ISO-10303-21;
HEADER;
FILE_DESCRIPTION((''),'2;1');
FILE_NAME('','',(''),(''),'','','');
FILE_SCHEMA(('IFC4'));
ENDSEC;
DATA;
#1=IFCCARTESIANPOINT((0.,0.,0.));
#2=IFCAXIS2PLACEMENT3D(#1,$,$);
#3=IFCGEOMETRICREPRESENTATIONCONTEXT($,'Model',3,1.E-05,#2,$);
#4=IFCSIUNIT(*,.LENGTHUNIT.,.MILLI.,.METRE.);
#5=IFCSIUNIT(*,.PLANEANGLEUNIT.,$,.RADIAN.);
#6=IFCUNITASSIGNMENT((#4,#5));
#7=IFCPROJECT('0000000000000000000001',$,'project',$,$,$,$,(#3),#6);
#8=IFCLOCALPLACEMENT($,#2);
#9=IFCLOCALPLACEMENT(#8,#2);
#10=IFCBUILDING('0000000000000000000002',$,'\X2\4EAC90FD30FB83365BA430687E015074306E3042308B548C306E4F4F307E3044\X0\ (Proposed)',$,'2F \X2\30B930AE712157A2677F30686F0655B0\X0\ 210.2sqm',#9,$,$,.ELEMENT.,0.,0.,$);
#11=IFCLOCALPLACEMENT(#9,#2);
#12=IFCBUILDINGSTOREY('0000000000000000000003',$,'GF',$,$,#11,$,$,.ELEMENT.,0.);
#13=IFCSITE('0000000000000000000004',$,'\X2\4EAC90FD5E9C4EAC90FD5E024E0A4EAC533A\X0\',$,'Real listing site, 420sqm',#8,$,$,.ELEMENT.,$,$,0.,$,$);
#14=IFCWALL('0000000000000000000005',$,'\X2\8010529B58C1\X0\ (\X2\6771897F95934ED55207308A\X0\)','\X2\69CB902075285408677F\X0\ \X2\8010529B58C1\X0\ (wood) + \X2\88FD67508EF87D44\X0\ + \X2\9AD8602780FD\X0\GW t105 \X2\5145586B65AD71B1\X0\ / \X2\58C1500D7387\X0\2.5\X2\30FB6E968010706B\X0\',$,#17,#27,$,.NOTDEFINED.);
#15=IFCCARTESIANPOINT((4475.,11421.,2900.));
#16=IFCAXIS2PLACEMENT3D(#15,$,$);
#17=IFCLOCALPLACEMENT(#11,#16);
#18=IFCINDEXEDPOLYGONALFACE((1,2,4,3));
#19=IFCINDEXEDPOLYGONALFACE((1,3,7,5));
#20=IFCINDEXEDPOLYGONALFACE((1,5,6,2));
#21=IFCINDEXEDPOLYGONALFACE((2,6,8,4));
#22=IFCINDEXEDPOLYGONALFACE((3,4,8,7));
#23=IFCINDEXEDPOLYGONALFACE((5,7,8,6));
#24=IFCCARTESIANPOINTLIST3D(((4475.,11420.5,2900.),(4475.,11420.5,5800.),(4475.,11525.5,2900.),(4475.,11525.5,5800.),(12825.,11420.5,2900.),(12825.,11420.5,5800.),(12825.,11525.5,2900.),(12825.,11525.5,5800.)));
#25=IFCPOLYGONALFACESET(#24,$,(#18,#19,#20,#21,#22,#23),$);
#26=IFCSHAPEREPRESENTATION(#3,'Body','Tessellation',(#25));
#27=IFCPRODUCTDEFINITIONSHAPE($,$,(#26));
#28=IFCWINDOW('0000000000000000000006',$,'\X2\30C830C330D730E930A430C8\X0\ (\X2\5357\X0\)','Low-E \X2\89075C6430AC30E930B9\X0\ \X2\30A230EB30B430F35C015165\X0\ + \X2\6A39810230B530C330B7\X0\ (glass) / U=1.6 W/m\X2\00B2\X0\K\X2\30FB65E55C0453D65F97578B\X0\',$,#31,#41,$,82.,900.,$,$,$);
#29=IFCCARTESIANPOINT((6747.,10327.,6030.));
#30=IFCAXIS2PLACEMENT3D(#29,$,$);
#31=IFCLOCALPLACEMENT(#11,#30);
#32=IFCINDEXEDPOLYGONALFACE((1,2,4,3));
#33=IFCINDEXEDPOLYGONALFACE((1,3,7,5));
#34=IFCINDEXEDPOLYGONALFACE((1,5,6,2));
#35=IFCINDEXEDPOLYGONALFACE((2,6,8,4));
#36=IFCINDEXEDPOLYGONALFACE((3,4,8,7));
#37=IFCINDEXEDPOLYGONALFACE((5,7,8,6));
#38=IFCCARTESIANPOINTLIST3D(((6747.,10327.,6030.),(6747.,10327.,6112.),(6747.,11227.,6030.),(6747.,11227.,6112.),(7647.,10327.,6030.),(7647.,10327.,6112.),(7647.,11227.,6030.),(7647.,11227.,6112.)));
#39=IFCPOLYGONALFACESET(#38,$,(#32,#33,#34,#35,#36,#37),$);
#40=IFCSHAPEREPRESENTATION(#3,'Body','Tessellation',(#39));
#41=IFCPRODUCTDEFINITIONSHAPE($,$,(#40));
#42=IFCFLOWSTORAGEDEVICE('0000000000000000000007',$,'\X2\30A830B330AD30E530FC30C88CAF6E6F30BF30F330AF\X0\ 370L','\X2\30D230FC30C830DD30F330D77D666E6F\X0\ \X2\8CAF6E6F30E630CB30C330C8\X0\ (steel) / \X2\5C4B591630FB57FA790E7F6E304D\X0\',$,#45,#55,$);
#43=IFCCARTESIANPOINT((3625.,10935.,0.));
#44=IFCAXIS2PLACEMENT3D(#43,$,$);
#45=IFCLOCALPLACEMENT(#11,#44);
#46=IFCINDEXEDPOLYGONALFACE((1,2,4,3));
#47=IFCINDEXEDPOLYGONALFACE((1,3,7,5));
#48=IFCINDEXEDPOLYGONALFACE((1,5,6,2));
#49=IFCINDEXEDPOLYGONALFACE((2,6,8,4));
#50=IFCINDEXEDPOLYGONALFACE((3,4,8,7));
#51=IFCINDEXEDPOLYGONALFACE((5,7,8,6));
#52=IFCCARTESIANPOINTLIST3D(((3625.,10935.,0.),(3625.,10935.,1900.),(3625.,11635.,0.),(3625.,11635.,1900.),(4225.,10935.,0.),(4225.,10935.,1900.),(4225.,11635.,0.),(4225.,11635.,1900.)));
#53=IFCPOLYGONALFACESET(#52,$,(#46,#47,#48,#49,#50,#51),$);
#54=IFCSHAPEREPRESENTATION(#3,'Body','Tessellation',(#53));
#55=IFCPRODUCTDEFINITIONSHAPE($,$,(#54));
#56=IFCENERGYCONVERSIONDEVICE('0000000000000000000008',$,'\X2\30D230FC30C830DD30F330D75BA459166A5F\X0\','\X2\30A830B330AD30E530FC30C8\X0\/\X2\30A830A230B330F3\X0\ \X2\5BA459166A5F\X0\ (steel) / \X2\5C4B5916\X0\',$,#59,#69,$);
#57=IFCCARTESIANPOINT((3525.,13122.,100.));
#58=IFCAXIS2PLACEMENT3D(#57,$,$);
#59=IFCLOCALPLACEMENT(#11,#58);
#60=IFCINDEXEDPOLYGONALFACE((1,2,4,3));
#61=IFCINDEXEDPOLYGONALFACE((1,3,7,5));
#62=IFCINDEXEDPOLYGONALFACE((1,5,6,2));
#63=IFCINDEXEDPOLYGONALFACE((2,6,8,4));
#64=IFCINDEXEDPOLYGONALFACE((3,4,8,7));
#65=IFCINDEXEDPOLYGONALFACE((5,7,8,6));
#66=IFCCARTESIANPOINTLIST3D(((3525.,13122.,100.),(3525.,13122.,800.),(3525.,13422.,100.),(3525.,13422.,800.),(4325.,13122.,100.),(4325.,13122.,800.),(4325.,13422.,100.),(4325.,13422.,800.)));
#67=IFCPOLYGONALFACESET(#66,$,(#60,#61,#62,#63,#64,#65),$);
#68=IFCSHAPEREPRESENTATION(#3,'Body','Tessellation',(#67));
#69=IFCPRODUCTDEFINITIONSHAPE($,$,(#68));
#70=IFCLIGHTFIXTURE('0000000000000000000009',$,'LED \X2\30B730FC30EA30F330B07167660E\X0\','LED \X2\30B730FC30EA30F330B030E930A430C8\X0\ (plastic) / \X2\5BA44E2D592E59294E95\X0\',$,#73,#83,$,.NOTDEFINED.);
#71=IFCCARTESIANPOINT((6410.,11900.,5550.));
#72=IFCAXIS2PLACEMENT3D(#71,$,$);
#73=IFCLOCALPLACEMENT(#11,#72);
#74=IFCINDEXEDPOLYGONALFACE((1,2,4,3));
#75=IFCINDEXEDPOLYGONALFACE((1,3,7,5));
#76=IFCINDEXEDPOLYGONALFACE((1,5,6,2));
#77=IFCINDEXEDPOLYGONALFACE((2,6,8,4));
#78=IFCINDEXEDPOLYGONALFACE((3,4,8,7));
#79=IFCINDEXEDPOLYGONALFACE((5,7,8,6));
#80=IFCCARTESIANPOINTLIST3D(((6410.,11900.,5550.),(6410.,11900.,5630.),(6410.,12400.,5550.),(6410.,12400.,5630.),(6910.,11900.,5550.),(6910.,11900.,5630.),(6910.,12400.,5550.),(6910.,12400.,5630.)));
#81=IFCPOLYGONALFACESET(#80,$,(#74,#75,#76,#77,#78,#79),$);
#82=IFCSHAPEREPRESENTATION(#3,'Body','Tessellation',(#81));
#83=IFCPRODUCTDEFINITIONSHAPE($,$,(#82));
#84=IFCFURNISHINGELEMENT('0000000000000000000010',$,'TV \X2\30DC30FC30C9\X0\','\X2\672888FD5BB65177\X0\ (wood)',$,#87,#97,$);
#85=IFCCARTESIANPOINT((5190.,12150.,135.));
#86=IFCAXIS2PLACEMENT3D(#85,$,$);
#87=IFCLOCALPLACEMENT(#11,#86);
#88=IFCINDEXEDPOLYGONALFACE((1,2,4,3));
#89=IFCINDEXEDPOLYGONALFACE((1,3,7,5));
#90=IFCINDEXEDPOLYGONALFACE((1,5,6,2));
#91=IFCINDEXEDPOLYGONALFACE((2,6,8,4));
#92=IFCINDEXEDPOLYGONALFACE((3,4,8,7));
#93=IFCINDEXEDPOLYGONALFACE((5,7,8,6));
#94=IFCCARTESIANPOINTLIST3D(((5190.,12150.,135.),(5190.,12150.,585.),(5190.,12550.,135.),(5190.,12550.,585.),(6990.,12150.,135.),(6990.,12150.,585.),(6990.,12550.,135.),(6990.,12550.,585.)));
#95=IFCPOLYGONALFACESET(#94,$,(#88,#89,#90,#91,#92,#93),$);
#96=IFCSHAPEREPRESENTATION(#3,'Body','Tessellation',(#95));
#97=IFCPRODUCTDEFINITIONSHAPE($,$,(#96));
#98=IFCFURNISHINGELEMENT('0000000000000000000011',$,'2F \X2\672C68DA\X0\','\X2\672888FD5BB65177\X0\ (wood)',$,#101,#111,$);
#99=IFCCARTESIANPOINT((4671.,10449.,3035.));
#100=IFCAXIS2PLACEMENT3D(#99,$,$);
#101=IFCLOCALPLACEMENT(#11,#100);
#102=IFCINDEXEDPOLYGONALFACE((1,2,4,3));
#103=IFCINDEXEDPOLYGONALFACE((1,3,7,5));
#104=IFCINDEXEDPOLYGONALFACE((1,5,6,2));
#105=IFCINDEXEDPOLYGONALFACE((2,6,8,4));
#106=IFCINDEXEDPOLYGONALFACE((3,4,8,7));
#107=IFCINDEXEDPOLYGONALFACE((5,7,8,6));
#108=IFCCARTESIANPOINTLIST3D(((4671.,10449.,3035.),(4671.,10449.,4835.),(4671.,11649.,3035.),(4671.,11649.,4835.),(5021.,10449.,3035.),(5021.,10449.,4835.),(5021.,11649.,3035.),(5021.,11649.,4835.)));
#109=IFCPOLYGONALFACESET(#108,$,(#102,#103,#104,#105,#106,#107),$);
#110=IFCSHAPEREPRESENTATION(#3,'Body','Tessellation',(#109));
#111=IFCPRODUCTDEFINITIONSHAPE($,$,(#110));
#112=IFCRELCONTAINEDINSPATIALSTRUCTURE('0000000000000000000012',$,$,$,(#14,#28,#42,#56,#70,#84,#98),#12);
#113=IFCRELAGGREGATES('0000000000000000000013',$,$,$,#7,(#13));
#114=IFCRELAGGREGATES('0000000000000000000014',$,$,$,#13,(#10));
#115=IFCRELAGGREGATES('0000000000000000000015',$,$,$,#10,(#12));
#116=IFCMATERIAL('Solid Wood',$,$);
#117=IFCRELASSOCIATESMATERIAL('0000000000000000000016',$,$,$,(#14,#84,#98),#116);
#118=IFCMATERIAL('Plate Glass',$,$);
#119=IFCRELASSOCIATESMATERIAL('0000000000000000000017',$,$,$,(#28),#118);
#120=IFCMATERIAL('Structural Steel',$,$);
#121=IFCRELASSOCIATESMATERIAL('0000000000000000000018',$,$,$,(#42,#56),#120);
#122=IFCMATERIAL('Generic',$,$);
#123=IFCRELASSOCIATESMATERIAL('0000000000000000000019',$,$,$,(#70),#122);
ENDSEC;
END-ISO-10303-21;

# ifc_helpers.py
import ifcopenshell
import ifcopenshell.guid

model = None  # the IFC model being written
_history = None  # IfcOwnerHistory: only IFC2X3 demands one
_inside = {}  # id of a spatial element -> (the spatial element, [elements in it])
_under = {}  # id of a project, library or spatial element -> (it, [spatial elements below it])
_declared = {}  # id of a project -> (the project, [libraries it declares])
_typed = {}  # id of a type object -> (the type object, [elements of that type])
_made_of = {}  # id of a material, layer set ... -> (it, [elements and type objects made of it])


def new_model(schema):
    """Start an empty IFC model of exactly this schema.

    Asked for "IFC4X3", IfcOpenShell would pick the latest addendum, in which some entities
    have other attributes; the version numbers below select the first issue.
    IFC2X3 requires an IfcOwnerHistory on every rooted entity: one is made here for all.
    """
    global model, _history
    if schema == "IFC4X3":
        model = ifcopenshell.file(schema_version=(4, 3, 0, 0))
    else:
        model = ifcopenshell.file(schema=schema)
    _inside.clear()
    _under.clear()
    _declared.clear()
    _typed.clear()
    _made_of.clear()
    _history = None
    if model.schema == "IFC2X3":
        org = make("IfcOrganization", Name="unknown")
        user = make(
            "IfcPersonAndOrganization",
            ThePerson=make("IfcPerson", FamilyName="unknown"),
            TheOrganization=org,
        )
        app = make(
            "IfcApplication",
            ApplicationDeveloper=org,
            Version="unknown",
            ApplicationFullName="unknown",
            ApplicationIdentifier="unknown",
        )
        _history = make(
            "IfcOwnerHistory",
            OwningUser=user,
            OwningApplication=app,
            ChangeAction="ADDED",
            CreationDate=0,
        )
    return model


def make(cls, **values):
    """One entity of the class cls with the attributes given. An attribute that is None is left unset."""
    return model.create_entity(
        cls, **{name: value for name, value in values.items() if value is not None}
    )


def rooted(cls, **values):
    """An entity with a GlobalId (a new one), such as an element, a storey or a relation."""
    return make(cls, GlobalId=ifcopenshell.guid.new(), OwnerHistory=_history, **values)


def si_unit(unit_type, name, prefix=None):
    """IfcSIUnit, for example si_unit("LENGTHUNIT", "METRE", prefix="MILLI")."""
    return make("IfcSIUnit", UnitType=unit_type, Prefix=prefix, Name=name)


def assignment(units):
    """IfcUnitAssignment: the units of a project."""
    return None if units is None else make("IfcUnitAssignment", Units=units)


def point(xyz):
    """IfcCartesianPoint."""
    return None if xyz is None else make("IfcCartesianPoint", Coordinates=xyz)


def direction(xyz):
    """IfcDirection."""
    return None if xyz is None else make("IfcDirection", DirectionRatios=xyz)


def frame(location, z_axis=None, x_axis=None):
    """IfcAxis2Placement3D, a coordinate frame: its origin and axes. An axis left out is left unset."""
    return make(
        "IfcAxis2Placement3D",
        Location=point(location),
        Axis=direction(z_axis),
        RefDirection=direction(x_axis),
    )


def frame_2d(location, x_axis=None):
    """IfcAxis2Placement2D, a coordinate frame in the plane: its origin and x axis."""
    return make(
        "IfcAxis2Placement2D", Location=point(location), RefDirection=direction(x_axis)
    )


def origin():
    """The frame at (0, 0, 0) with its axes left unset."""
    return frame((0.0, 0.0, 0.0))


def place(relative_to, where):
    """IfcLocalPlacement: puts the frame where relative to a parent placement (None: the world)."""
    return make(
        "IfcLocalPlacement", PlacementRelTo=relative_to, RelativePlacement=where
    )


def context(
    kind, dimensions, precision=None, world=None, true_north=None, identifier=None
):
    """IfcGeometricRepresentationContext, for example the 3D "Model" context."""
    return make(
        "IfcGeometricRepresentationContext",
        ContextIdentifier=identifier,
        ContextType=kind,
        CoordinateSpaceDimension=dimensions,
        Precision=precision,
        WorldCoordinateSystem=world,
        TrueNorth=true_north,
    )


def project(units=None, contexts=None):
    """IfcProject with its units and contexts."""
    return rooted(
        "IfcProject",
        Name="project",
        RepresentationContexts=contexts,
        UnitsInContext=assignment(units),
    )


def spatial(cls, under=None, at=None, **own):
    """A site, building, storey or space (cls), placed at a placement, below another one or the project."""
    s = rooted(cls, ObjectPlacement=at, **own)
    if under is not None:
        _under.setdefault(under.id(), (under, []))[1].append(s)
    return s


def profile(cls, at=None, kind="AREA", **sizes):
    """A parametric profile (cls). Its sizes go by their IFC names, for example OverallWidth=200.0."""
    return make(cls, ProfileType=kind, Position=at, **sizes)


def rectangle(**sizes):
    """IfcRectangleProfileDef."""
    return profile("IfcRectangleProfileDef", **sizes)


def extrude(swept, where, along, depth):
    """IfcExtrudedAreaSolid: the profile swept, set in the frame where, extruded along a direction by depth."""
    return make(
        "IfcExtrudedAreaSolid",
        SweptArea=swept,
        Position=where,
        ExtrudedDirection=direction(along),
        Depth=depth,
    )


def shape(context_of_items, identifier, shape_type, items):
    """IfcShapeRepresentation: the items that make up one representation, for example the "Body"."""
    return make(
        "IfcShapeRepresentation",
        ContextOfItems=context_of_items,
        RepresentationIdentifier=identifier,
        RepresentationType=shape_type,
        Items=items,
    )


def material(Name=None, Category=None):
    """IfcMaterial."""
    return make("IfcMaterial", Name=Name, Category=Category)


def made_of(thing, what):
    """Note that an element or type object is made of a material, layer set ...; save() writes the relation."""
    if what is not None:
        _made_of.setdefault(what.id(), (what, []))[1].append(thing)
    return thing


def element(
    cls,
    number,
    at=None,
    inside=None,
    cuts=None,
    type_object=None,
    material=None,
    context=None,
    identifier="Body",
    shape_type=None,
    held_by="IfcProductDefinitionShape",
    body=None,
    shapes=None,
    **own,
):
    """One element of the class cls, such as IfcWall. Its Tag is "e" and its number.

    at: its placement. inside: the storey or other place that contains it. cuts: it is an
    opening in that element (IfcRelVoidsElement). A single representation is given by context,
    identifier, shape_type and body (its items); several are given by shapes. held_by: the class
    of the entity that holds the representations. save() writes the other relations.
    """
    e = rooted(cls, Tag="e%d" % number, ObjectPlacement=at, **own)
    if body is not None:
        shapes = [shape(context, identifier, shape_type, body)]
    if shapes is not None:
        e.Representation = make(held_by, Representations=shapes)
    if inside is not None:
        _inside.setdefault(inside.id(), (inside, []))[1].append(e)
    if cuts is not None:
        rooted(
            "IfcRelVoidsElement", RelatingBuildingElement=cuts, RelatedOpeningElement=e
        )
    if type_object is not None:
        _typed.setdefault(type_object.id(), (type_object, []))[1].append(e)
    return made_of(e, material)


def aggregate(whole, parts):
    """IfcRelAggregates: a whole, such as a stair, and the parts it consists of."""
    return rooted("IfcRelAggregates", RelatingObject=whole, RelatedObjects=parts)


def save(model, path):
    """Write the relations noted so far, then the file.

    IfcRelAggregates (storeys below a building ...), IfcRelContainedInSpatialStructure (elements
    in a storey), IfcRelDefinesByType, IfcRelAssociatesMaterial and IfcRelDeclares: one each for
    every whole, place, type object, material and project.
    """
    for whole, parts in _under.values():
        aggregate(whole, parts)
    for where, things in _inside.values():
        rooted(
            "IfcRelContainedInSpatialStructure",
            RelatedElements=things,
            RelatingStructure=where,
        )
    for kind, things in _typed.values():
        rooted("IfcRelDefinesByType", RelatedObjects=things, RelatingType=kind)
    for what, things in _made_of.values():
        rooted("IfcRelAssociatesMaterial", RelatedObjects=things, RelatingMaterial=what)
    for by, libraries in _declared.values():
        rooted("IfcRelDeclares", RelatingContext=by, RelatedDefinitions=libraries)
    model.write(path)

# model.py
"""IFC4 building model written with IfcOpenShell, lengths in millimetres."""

from ifc_helpers import new_model, si_unit, frame, frame_2d, origin, place, context, project, spatial, rectangle, extrude, material, element, save


model = new_model("IFC4")

# Units and contexts
model_context = context("Model", 3, precision=1e-05, world=origin())
ifc_project = project(units=[si_unit("LENGTHUNIT", "METRE", prefix="MILLI"), si_unit("PLANEANGLEUNIT", "RADIAN")], contexts=[model_context])

# Site, building, storey
site_placement = place(None, origin())
site = spatial("IfcSite", under=ifc_project, at=site_placement, Name="京都府京都市上京区", ObjectType="Real listing site, 420sqm", CompositionType="ELEMENT", RefElevation=0.0)
building_placement = place(site_placement, origin())
building = spatial("IfcBuilding", under=site, at=building_placement, Name="京都・茶室と縁側のある和の住まい (Proposed)", ObjectType="2F スギ無垢板と漆喰 210.2sqm", CompositionType="ELEMENT", ElevationOfRefHeight=0.0, ElevationOfTerrain=0.0)
storey_placement = place(building_placement, origin())
storey = spatial("IfcBuildingStorey", under=building, at=storey_placement, Name="GF", CompositionType="ELEMENT", Elevation=0.0)

# Shared definitions
ifc_material_1 = material(Name="Solid Wood")

# Wall
wall_1_placement = place(storey_placement, frame((4475.0, 11421.0, 2900.0)))
element("IfcWall", 1, at=wall_1_placement, inside=storey, material=ifc_material_1, Name="耐力壁 (東西間仕切り)", Description="構造用合板 耐力壁 (wood) + 製材軸組 + 高性能GW t105 充填断熱 / 壁倍率2.5・準耐火", PredefinedType="NOTDEFINED", context=model_context, shape_type="SweptSolid", body=[
    extrude(rectangle(XDim=8350.0, YDim=105.0, at=frame_2d((4175.0, 52.0))), frame((4475.0, 11421.0, 2900.0)), (0.0, 0.0, 1.0), 2900.0),
])

# Window
ifc_material_2 = material(Name="Plate Glass")
window_placement = place(storey_placement, frame((6747.0, 10327.0, 6030.0)))
element("IfcWindow", 2, at=window_placement, inside=storey, material=ifc_material_2, Name="トップライト (南)", Description="Low-E 複層ガラス アルゴン封入 + 樹脂サッシ (glass) / U=1.6 W/m²K・日射取得型", OverallHeight=82.0, OverallWidth=900.0, context=model_context, shape_type="SweptSolid", body=[
    extrude(rectangle(XDim=900.0, YDim=900.0, at=frame_2d((450.0, 450.0))), frame((6747.0, 10327.0, 6030.0)), (0.0, 0.0, 1.0), 82.0),
])

# Flow storage device
ifc_material_3 = material(Name="Structural Steel")
flow_storage_device_placement = place(storey_placement, frame((3625.0, 10935.0, 0.0)))
element("IfcFlowStorageDevice", 3, at=flow_storage_device_placement, inside=storey, material=ifc_material_3, Name="エコキュート貯湯タンク 370L", Description="ヒートポンプ給湯 貯湯ユニット (steel) / 屋外・基礎置き", context=model_context, shape_type="SweptSolid", body=[
    extrude(rectangle(XDim=600.0, YDim=700.0, at=frame_2d((300.0, 350.0))), frame((3625.0, 10935.0, 0.0)), (0.0, 0.0, 1.0), 1900.0),
])

# Energy conversion device
energy_conversion_device_placement = place(storey_placement, frame((3525.0, 13122.0, 100.0)))
element("IfcEnergyConversionDevice", 4, at=energy_conversion_device_placement, inside=storey, material=ifc_material_3, Name="ヒートポンプ室外機", Description="エコキュート/エアコン 室外機 (steel) / 屋外", context=model_context, shape_type="SweptSolid", body=[
    extrude(rectangle(XDim=800.0, YDim=300.0, at=frame_2d((400.0, 150.0))), frame((3525.0, 13122.0, 100.0)), (0.0, 0.0, 1.0), 700.0),
])

# Light fixture
ifc_material_4 = material(Name="Generic")
light_fixture_placement = place(storey_placement, frame((6410.0, 11900.0, 5550.0)))
element("IfcLightFixture", 5, at=light_fixture_placement, inside=storey, material=ifc_material_4, Name="LED シーリング照明", Description="LED シーリングライト (plastic) / 室中央天井", PredefinedType="NOTDEFINED", context=model_context, shape_type="SweptSolid", body=[
    extrude(rectangle(XDim=500.0, YDim=500.0, at=frame_2d((250.0, 250.0))), frame((6410.0, 11900.0, 5550.0)), (0.0, 0.0, 1.0), 80.0),
])

# Furnishing elements
furnishing_1_placement = place(storey_placement, frame((5190.0, 12150.0, 135.0)))
element("IfcFurnishingElement", 6, at=furnishing_1_placement, inside=storey, material=ifc_material_1, Name="TV ボード", Description="木製家具 (wood)", context=model_context, shape_type="SweptSolid", body=[
    extrude(rectangle(XDim=1800.0, YDim=400.0, at=frame_2d((900.0, 200.0))), frame((5190.0, 12150.0, 135.0)), (0.0, 0.0, 1.0), 450.0),
])
furnishing_2_placement = place(storey_placement, frame((4671.0, 10449.0, 3035.0)))
element("IfcFurnishingElement", 7, at=furnishing_2_placement, inside=storey, material=ifc_material_1, Name="2F 本棚", Description="木製家具 (wood)", context=model_context, shape_type="SweptSolid", body=[
    extrude(rectangle(XDim=350.0, YDim=1200.0, at=frame_2d((175.0, 600.0))), frame((4671.0, 10449.0, 3035.0)), (0.0, 0.0, 1.0), 1800.0),
])

save(model, "model.ifc")
